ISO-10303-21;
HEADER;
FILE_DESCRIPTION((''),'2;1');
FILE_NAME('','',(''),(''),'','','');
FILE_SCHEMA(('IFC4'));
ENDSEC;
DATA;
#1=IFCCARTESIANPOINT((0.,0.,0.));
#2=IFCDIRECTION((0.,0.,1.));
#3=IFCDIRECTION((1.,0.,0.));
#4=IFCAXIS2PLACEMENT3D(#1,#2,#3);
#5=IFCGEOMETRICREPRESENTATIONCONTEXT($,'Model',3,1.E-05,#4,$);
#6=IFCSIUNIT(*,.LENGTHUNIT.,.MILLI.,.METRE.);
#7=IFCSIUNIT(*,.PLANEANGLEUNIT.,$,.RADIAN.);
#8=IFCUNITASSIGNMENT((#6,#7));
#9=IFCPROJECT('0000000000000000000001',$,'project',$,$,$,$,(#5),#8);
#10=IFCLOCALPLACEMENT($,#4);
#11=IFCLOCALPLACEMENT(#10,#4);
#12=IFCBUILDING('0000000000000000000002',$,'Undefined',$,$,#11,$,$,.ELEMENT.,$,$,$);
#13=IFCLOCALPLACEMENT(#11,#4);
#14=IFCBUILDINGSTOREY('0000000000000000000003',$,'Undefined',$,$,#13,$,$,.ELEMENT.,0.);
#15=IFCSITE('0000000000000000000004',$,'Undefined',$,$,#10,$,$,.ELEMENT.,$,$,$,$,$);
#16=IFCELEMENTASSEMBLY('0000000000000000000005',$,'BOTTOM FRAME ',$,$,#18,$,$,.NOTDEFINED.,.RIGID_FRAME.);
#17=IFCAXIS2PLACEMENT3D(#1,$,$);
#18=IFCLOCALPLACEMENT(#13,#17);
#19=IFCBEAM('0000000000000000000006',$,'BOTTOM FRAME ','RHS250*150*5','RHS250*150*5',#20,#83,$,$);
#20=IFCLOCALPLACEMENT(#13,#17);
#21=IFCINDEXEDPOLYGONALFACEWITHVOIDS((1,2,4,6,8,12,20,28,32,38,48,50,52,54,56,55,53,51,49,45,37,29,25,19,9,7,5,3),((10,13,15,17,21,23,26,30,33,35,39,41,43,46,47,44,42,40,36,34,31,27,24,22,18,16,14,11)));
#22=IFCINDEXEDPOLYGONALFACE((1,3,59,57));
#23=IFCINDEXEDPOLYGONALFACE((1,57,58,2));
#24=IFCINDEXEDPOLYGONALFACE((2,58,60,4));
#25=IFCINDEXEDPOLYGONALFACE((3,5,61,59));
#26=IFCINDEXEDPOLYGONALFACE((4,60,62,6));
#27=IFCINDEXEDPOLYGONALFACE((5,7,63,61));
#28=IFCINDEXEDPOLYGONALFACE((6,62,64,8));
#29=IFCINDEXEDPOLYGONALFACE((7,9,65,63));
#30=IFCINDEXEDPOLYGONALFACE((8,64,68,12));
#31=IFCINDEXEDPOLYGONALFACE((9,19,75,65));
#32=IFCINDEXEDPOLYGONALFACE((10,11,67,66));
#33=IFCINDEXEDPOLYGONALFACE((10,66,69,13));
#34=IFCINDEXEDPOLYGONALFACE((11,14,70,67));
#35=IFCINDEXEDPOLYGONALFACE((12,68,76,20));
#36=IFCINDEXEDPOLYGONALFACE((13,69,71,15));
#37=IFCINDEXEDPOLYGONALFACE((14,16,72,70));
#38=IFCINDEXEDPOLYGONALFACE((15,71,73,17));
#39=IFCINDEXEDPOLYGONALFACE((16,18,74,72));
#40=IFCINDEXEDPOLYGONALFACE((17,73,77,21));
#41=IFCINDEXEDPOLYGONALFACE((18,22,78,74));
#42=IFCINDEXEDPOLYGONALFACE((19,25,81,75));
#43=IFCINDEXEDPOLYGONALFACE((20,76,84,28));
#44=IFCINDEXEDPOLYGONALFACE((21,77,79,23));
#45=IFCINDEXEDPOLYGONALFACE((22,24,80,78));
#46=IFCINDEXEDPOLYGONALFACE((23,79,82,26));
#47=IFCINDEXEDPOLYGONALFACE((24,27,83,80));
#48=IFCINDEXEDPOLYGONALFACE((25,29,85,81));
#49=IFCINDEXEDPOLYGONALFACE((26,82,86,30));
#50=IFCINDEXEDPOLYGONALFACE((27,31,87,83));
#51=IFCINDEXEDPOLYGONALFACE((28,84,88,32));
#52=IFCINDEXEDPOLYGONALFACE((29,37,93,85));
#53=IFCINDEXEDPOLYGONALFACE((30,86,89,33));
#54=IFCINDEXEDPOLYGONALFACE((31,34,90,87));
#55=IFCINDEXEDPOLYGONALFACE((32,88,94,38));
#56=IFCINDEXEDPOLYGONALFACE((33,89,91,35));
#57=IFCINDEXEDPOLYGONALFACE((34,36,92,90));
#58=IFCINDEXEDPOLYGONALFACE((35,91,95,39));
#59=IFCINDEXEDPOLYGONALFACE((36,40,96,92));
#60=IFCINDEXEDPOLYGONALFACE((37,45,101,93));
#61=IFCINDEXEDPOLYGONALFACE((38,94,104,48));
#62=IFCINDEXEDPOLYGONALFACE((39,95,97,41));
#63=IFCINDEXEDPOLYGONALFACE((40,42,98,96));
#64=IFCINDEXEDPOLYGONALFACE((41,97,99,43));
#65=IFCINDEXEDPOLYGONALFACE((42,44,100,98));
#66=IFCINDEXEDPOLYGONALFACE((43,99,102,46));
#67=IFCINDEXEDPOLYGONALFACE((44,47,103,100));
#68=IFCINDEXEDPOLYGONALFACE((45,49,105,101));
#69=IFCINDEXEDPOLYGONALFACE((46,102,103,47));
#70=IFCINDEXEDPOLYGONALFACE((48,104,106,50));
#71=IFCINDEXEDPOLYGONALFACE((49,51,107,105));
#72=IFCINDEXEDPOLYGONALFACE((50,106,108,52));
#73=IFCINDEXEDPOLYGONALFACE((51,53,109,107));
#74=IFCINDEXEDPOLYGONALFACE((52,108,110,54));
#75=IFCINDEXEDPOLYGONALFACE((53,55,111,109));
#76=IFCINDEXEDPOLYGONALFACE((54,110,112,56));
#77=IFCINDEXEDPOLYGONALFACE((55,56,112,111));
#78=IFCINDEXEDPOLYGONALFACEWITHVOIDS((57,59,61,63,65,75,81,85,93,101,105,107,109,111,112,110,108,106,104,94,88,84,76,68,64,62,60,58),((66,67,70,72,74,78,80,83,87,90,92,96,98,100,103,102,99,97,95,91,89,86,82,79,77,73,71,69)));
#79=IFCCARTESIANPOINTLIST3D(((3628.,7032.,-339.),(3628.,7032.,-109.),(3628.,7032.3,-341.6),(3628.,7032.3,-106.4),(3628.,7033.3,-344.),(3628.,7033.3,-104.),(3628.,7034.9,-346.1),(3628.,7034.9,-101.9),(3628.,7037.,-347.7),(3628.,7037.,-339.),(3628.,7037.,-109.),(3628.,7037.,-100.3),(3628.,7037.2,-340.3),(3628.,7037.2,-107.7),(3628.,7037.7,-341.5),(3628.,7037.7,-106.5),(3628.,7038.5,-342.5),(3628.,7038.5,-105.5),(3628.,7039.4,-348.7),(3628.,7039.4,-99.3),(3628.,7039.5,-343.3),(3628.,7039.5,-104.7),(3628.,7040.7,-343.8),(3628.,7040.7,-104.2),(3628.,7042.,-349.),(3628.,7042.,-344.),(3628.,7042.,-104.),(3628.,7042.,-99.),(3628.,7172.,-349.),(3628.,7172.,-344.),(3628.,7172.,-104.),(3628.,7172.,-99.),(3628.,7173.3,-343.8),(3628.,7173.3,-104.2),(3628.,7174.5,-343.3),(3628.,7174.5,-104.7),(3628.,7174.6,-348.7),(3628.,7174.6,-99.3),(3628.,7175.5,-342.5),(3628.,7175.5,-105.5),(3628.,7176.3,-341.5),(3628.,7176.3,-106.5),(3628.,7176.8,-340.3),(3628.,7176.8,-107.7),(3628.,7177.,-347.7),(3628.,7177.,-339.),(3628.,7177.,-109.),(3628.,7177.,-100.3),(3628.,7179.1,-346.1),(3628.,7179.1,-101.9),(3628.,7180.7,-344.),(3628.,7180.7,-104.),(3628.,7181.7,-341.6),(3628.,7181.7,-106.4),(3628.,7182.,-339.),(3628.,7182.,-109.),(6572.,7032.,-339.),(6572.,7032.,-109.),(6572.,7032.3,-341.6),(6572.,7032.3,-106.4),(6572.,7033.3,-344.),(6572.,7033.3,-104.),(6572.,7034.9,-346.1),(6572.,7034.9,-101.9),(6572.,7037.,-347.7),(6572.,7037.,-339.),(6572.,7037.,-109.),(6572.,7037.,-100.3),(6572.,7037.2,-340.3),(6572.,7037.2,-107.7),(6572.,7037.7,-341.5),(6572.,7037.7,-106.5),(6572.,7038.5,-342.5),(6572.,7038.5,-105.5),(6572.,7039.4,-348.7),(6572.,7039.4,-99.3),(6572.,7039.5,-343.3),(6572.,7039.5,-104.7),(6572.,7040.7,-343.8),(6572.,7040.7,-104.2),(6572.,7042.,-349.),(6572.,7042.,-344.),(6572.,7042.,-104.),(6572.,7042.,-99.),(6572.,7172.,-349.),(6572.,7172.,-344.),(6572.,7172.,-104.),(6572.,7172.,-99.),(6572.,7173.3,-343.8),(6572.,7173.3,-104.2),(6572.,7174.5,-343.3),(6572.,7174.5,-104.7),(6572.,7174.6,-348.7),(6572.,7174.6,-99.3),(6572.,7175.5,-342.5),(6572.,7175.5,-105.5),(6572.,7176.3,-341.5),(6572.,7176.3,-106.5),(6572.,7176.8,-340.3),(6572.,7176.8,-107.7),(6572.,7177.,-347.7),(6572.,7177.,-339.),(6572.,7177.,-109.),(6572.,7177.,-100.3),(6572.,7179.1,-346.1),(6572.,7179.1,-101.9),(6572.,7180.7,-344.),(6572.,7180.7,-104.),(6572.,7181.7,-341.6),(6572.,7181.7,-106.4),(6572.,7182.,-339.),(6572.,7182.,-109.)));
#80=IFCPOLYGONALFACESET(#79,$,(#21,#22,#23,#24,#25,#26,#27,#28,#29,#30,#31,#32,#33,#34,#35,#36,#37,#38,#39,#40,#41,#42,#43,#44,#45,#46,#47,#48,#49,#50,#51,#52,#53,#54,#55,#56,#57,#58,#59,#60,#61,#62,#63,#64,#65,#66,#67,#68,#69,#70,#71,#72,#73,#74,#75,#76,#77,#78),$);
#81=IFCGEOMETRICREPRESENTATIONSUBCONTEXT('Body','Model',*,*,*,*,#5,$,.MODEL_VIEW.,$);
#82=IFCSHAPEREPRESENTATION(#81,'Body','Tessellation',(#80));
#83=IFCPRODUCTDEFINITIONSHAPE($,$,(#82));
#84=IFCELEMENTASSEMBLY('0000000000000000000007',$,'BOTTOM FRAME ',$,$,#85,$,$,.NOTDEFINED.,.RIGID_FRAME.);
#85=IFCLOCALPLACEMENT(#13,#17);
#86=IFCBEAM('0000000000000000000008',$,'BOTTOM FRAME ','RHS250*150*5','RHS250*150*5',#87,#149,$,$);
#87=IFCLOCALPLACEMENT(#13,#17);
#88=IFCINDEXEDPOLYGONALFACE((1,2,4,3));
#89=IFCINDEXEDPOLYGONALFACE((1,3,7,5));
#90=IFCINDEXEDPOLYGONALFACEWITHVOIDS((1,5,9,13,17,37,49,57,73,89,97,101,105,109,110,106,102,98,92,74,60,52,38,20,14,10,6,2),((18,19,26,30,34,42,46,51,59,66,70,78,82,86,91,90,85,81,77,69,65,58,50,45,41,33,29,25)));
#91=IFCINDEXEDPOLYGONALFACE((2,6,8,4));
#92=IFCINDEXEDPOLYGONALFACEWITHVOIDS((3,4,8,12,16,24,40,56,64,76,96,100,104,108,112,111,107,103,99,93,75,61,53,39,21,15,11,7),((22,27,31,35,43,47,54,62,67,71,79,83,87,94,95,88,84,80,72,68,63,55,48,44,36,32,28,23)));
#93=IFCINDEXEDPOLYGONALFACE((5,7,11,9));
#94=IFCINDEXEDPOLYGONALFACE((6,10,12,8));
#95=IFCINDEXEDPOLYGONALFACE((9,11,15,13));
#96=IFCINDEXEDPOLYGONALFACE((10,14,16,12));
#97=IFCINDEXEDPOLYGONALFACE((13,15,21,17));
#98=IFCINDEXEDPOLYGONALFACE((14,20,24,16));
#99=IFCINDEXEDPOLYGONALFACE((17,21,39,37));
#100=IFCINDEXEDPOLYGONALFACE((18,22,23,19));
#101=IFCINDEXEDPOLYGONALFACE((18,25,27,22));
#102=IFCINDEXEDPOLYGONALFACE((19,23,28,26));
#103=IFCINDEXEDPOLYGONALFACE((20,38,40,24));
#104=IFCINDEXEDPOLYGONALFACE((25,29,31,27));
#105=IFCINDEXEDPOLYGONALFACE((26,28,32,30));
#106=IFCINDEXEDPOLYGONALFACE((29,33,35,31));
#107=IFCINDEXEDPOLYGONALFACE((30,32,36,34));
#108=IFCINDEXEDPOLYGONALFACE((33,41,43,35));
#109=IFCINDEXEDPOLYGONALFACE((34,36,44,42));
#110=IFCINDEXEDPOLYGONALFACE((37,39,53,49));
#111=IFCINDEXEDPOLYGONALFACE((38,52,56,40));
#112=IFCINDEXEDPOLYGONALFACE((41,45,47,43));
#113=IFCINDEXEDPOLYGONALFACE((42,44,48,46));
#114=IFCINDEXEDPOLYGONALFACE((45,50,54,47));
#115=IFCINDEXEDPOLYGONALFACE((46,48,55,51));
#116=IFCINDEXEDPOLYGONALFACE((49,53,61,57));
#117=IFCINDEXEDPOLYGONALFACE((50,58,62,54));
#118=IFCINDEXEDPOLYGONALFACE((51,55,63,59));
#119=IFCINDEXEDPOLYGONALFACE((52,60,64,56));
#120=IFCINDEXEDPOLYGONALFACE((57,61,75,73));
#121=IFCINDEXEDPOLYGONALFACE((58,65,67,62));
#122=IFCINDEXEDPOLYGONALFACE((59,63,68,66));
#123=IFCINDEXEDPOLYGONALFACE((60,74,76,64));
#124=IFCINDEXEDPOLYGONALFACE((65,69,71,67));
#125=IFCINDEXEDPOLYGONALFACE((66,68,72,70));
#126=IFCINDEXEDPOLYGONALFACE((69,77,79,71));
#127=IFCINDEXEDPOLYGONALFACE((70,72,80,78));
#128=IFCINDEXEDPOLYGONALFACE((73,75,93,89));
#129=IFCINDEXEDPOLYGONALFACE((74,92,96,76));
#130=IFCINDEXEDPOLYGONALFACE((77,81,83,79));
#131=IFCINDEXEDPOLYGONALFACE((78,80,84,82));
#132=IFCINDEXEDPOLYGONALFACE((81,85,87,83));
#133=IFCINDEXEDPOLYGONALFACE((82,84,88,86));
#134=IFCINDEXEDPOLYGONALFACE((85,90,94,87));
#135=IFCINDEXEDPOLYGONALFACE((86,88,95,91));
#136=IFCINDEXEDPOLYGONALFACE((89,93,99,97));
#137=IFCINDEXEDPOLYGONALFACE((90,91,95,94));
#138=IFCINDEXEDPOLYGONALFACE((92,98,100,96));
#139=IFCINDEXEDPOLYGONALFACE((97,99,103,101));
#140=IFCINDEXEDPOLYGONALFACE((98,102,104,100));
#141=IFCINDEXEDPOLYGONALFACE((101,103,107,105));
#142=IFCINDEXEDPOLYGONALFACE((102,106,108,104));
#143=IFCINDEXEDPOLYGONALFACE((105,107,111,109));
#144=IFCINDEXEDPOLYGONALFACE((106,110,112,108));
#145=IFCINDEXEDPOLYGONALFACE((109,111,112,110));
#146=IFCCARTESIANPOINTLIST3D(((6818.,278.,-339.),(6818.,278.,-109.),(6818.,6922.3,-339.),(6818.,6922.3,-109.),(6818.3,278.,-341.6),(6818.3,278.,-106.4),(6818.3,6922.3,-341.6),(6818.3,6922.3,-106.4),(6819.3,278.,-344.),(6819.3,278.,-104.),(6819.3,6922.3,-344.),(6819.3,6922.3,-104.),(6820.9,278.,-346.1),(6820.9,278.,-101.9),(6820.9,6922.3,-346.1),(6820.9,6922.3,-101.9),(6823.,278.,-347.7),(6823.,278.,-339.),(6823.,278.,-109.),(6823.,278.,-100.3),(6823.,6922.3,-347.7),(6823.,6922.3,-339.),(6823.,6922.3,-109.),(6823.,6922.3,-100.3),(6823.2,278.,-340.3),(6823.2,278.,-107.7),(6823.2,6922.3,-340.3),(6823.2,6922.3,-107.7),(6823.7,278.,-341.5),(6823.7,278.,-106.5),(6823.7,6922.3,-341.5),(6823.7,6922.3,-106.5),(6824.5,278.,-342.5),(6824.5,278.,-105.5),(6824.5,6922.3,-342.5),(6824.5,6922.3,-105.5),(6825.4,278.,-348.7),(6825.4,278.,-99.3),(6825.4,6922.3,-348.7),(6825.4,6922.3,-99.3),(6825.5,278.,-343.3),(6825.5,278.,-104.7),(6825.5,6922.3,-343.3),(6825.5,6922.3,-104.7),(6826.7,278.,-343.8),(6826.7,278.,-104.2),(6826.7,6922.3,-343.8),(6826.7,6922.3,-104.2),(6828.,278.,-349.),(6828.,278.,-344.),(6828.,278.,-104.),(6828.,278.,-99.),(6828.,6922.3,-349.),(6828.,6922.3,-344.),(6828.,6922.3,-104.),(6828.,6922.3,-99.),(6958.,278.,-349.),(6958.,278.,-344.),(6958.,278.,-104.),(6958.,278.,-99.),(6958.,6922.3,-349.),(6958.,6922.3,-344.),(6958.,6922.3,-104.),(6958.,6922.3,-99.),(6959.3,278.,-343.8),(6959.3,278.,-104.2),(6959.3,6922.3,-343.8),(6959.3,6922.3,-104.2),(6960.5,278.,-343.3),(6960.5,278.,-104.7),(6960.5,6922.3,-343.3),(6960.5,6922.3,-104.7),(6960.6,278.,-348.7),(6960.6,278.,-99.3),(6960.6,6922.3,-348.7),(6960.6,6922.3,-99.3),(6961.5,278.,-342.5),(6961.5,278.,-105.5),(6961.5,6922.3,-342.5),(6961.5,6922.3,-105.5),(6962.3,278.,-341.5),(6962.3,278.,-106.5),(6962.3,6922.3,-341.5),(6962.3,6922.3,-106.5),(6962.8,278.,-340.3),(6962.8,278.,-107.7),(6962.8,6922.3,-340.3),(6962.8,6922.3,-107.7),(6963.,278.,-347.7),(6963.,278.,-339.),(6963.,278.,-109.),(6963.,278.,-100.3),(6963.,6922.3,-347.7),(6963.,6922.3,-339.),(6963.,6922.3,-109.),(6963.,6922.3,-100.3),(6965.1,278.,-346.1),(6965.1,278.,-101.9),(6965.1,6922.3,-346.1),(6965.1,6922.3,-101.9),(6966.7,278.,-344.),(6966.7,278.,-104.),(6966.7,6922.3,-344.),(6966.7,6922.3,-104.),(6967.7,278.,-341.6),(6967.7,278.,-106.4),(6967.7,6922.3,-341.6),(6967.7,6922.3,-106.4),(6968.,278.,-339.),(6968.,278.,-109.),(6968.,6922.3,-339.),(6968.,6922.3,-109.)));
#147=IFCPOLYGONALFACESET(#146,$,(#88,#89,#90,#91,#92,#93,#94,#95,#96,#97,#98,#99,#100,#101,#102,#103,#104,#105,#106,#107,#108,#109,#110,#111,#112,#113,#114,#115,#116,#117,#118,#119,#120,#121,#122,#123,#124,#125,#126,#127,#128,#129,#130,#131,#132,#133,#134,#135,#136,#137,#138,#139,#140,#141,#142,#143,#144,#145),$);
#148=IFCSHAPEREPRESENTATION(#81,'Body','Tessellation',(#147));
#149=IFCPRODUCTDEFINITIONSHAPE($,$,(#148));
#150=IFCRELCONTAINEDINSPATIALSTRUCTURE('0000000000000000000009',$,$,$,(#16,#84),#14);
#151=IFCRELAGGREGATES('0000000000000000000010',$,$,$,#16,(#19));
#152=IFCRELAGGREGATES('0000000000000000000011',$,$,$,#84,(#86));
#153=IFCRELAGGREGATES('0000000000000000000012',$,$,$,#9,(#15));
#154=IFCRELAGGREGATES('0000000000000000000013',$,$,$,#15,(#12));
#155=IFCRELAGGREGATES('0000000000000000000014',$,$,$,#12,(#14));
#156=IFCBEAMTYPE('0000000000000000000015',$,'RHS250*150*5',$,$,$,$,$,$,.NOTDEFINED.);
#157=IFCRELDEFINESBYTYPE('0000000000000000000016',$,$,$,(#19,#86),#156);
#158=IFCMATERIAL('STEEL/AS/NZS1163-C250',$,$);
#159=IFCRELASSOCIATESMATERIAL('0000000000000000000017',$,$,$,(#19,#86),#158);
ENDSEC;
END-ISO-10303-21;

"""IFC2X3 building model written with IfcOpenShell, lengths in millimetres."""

from ifc_helpers import new_model, si_unit, frame, origin_with_axes, origin_2d_with_axis, place, context, subcontext, project, spatial, hollow_rectangle, extrude, material, type_object, element, aggregate, save


model = new_model("IFC2X3")

# Units and contexts
model_context = context("Model", 3, precision=1e-05, world=origin_with_axes())
body_context = subcontext(model_context, "Body", "Model", "MODEL_VIEW")
ifc_project = project(units=[si_unit("LENGTHUNIT", "METRE", prefix="MILLI"), si_unit("PLANEANGLEUNIT", "RADIAN")], contexts=[model_context])

# Site, building, storey
site_placement = place(None, origin_with_axes())
site = spatial("IfcSite", under=ifc_project, at=site_placement, Name="Undefined", CompositionType="ELEMENT")
building_placement = place(site_placement, origin_with_axes())
building = spatial("IfcBuilding", under=site, at=building_placement, Name="Undefined", CompositionType="ELEMENT")
storey_placement = place(building_placement, origin_with_axes())
storey = spatial("IfcBuildingStorey", under=building, at=storey_placement, Name="Undefined", CompositionType="ELEMENT", Elevation=0.0)

# Element assembly
assembly_1_placement = place(storey_placement, origin_with_axes())
assembly_1 = element("IfcElementAssembly", 1, at=assembly_1_placement, inside=storey, Name="BOTTOM FRAME ", AssemblyPlace="NOTDEFINED", PredefinedType="RIGID_FRAME")
ifc_material_1 = material(Name="STEEL/AS/NZS1163-C250")

# Beam
beam_type_1 = type_object("IfcBeamType", Name="RHS250*150*5", PredefinedType="NOTDEFINED")
beam_1_placement = place(assembly_1_placement, frame((6572.0, 7107.0, -224.0), z_axis=(0.0, 0.0, 1.0), x_axis=(-1.0, 0.0, 0.0)))
beam_1 = element("IfcBeam", 2, at=beam_1_placement, type_object=beam_type_1, material=ifc_material_1, Name="BOTTOM FRAME ", Description="RHS250*150*5", ObjectType="RHS250*150*5", context=body_context, shape_type="SweptSolid", body=[
    extrude(hollow_rectangle(XDim=150.0, YDim=250.0, WallThickness=5.0, InnerFilletRadius=5.0, OuterFilletRadius=10.0, at=origin_2d_with_axis()), frame((2944.0, 0.0, 0.0), z_axis=(-1.0, 0.0, 0.0), x_axis=(0.0, -1.0, 0.0)), (0.0, 0.0, 1.0), 2944.0),
])
aggregate(assembly_1, [beam_1])

# Element assembly, beam
assembly_2_placement = place(storey_placement, origin_with_axes())
assembly_2 = element("IfcElementAssembly", 3, at=assembly_2_placement, inside=storey, Name="BOTTOM FRAME ", AssemblyPlace="NOTDEFINED", PredefinedType="RIGID_FRAME")
beam_2_placement = place(assembly_2_placement, frame((6893.0, 6922.3, -224.0), z_axis=(0.0, 0.0, 1.0), x_axis=(0.0, -1.0, 0.0)))
beam_2 = element("IfcBeam", 4, at=beam_2_placement, type_object=beam_type_1, material=ifc_material_1, Name="BOTTOM FRAME ", Description="RHS250*150*5", ObjectType="RHS250*150*5", context=body_context, shape_type="SweptSolid", body=[
    extrude(hollow_rectangle(XDim=150.0, YDim=250.0, WallThickness=5.0, InnerFilletRadius=5.0, OuterFilletRadius=10.0, at=origin_2d_with_axis()), frame((6644.3, 0.0, 0.0), z_axis=(-1.0, 0.0, 0.0), x_axis=(0.0, -1.0, 0.0)), (0.0, 0.0, 1.0), 6644.3),
])
aggregate(assembly_2, [beam_2])

save(model, "model.ifc")
